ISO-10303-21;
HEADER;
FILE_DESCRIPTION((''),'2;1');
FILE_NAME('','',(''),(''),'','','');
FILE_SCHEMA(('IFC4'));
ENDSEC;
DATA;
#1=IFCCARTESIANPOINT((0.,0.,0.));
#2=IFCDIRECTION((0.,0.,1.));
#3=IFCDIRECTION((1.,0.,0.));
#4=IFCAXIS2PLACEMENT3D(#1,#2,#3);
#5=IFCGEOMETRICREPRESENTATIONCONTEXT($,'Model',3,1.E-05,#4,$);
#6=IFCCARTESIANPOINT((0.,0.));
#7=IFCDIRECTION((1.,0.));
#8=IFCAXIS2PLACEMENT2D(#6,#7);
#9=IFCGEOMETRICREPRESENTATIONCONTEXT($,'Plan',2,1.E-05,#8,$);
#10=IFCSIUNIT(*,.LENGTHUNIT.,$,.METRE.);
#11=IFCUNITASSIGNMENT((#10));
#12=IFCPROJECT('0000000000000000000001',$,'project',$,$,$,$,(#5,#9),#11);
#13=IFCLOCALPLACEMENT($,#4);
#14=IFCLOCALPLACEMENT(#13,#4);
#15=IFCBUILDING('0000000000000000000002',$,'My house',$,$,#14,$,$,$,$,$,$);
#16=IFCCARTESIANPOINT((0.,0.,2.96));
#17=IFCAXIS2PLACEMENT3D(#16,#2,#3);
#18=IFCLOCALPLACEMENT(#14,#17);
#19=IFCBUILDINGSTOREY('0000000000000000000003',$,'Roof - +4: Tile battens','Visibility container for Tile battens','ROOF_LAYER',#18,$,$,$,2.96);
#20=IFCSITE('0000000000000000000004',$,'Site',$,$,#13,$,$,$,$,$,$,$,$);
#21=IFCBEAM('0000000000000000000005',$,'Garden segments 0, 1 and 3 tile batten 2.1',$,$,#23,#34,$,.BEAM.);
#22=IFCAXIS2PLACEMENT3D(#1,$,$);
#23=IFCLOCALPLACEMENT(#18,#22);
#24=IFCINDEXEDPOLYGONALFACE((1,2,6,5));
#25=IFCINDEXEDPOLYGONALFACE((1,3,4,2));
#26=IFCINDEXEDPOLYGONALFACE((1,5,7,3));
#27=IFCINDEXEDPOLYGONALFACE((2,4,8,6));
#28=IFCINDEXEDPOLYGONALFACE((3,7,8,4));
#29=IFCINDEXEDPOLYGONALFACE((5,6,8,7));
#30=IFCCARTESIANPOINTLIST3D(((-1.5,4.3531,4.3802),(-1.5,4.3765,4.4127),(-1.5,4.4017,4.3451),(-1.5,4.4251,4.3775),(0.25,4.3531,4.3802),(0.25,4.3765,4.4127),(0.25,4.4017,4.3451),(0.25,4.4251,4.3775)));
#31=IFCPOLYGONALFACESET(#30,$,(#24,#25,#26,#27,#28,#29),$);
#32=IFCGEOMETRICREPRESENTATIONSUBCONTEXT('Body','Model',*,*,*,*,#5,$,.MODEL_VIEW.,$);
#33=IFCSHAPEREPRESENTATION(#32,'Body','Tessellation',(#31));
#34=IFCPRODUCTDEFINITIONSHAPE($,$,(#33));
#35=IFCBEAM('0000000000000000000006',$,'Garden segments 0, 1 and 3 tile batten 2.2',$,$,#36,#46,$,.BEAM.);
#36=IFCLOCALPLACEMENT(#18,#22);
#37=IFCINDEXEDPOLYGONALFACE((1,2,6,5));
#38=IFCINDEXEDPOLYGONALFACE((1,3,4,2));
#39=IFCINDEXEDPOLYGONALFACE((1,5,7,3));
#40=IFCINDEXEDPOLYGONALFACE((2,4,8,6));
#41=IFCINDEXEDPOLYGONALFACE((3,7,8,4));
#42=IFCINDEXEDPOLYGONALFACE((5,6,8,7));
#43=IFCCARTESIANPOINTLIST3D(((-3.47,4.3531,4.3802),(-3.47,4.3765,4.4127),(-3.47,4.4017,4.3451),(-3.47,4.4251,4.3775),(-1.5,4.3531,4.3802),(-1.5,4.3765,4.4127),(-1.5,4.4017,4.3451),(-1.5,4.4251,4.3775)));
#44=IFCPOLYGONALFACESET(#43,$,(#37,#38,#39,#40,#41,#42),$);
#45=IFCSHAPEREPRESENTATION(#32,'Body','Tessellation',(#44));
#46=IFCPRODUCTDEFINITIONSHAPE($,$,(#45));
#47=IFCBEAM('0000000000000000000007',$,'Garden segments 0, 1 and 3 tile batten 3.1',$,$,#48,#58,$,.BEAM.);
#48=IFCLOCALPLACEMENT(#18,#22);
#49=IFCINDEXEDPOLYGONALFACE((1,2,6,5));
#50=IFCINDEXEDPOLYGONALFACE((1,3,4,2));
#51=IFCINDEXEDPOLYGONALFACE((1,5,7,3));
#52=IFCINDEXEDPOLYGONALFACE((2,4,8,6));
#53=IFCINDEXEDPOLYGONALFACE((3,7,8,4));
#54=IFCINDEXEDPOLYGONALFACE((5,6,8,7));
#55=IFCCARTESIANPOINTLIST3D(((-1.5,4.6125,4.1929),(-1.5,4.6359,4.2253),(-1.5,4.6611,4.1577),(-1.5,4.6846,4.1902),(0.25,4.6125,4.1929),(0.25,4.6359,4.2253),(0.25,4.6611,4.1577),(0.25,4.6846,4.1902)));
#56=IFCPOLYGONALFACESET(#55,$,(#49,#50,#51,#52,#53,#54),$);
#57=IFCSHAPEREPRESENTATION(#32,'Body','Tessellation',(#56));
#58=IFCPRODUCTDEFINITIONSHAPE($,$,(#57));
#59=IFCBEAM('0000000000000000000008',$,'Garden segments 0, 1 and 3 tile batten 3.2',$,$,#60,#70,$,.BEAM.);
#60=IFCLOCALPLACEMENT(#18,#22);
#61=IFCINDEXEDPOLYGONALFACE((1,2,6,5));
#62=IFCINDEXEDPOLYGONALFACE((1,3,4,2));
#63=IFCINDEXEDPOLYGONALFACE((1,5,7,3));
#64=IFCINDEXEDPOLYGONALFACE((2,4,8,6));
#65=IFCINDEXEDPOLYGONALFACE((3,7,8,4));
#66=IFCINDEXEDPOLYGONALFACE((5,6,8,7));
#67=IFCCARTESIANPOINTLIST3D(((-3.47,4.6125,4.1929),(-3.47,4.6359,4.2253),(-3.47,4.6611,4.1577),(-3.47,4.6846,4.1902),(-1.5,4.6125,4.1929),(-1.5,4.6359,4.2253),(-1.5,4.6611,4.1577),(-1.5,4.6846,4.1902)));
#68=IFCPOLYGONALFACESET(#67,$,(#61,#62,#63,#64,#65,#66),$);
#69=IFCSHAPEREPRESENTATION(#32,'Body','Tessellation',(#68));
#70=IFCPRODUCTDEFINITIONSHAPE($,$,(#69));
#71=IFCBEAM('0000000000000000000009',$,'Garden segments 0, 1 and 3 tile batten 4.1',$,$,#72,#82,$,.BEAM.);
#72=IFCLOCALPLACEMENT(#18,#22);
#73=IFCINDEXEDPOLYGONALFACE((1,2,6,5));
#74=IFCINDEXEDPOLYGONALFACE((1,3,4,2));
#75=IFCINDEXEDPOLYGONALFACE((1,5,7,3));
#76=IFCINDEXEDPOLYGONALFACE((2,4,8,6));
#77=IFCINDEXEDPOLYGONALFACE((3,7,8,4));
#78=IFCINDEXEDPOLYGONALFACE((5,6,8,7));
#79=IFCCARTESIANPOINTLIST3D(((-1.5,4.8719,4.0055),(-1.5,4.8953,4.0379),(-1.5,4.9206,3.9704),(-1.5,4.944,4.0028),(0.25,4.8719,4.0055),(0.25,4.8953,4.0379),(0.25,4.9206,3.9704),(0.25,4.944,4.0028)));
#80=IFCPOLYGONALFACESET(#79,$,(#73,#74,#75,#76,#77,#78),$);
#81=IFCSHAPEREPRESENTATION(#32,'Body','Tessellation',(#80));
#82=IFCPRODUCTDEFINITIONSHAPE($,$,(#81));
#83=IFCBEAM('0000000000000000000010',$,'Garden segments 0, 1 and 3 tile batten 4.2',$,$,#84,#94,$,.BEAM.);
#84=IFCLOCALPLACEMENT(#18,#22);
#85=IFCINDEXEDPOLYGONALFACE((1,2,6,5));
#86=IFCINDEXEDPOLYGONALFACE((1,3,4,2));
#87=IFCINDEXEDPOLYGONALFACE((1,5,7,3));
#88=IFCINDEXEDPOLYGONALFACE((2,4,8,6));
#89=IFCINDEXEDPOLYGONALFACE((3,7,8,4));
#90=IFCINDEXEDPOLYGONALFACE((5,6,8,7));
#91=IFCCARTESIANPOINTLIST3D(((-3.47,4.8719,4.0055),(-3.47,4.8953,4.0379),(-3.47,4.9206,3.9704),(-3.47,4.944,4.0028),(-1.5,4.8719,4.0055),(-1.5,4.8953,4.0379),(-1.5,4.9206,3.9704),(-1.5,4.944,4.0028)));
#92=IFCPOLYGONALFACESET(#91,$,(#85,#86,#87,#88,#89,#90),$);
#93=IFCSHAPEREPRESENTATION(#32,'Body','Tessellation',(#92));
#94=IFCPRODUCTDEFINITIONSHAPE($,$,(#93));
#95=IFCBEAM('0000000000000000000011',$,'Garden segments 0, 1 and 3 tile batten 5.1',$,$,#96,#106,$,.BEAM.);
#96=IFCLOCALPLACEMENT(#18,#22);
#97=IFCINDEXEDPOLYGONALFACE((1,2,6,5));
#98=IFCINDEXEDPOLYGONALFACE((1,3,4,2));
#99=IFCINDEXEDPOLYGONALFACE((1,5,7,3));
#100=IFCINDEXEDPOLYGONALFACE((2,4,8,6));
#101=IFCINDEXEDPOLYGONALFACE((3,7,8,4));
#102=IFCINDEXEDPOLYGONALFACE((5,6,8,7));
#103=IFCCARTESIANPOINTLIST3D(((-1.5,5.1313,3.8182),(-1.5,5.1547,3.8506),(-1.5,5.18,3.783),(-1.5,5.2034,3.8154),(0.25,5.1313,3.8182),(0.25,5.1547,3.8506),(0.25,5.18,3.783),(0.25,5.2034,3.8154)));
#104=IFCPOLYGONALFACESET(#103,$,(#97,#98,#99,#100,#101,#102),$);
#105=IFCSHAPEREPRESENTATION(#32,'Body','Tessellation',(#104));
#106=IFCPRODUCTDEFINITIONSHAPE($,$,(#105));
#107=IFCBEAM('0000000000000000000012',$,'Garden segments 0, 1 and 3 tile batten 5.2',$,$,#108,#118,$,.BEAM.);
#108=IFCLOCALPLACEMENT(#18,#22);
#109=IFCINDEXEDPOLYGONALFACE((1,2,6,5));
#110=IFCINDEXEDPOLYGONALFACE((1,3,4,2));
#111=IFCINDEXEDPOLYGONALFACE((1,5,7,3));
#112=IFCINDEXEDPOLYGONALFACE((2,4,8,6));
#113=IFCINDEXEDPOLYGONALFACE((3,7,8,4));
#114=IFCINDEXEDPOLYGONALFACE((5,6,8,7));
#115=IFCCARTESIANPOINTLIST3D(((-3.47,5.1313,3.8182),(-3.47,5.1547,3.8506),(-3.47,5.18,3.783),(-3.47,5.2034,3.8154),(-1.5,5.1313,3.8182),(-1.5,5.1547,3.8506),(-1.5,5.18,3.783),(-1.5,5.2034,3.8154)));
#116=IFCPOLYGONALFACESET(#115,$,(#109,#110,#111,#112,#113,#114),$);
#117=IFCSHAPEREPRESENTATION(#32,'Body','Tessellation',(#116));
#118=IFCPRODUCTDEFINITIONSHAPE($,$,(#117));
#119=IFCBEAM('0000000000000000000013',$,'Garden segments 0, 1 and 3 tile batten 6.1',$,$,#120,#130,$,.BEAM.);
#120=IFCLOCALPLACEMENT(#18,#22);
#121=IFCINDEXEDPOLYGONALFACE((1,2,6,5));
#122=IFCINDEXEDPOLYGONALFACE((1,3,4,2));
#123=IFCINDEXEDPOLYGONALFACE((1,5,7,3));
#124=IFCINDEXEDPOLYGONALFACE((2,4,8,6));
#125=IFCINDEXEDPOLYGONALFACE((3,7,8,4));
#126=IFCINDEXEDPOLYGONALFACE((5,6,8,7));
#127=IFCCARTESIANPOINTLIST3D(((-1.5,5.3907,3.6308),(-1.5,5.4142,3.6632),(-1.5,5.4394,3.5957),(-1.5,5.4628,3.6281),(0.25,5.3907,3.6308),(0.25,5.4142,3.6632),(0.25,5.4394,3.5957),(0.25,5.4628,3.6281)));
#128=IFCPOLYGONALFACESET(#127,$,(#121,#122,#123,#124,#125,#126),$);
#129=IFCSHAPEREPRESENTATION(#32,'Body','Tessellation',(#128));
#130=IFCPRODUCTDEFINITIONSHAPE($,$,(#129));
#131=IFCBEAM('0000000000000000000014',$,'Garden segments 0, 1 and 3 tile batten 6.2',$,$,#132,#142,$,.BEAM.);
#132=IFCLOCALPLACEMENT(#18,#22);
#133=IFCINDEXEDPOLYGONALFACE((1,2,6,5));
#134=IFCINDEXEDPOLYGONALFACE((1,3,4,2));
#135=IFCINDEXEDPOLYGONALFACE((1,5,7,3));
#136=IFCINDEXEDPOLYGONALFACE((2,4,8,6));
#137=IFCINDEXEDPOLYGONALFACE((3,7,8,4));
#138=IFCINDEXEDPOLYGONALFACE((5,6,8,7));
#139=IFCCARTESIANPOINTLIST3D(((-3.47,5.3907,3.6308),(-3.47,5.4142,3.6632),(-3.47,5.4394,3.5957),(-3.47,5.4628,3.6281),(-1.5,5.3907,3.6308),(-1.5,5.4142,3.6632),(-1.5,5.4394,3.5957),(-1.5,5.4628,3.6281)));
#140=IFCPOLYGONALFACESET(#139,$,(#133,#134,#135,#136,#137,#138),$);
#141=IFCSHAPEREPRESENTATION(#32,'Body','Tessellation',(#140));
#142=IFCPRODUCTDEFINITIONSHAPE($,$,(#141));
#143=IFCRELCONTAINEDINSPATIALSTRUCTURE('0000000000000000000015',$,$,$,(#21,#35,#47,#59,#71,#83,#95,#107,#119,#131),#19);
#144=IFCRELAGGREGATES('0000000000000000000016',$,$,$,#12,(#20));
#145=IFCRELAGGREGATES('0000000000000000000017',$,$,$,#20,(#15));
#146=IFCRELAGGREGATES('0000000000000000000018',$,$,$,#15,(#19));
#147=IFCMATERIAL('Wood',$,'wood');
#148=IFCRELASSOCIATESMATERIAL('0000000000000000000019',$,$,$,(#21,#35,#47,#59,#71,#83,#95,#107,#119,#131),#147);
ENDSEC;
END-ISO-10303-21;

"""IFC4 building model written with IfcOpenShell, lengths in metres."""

from ifc_helpers import new_model, si_unit, frame, origin_with_axes, origin_2d_with_axis, place, context, subcontext, project, spatial, rectangle, extrude, clip, halfspace, source, transform, mapped, material, element, save


model = new_model("IFC4")

# Units and contexts
model_context = context("Model", 3, precision=1e-05, world=origin_with_axes())
plan_context = context("Plan", 2, precision=1e-05, world=origin_2d_with_axis())
body_context = subcontext(model_context, "Body", "Model", "MODEL_VIEW")
ifc_project = project(units=[si_unit("LENGTHUNIT", "METRE")], contexts=[model_context, plan_context])

# Site, building, storey
site_placement = place(None, origin_with_axes())
site = spatial("IfcSite", under=ifc_project, at=site_placement, Name="Site")
building_placement = place(site_placement, origin_with_axes())
building = spatial("IfcBuilding", under=site, at=building_placement, Name="My house")
storey_placement = place(building_placement, frame((0.0, 0.0, 2.96), z_axis=(0.0, 0.0, 1.0), x_axis=(1.0, 0.0, 0.0)))
storey = spatial("IfcBuildingStorey", under=building, at=storey_placement, Name="Roof - +4: Tile battens", Description="Visibility container for Tile battens", ObjectType="ROOF_LAYER", Elevation=2.96)

# Beams
ifc_material = material(Name="Wood", Category="wood")
shared_shape_1 = source(origin_with_axes(), body_context, "Body", "Clipping", [
    clip(clip(extrude(rectangle(XDim=0.06, YDim=0.04), frame((0.0, 0.0, 0.0), z_axis=(1.0, 0.0, 0.0), x_axis=(0.0, 1.0, 0.0)), (0.0, 0.0, 1.0), 1.75), halfspace(frame((0.25, 3.9816, -6.1772), z_axis=(0.0, -0.810664, -0.585512), x_axis=(-1.0, 0.0, 0.0)), False)), halfspace(frame((0.25, 7.8322, -3.396), z_axis=(0.0, 0.810664, 0.585512), x_axis=(1.0, 0.0, 0.0)), False)),
])
beam_1_placement = place(storey_placement, frame((0.25, 4.3891, 4.3789), z_axis=(0.0, 0.585512, 0.810664), x_axis=(1.0, 0.0, 0.0)))
element("IfcBeam", 1, at=beam_1_placement, inside=storey, material=ifc_material, Name="Garden segments 0, 1 and 3 tile batten 2.1", PredefinedType="BEAM", context=body_context, shape_type="MappedRepresentation", body=[
    mapped(shared_shape_1, transform((0.0, 0.0, 0.0), x_axis=(-1.0, 0.0, 0.0), y_axis=(0.0, 1.0, 0.0), z_axis=(0.0, 0.0, 1.0), scale=1.0)),
])
shared_shape_2 = source(origin_with_axes(), body_context, "Body", "Clipping", [
    clip(clip(extrude(rectangle(XDim=0.06, YDim=0.04), frame((0.0, 0.0, 0.0), z_axis=(1.0, 0.0, 0.0), x_axis=(0.0, 1.0, 0.0)), (0.0, 0.0, 1.0), 1.97), halfspace(frame((-1.5, 3.9816, -6.1772), z_axis=(0.0, -0.810664, -0.585512), x_axis=(-1.0, 0.0, 0.0)), False)), halfspace(frame((-1.5, 7.8322, -3.396), z_axis=(0.0, 0.810664, 0.585512), x_axis=(1.0, 0.0, 0.0)), False)),
])
beam_2_placement = place(storey_placement, frame((-1.5, 4.3891, 4.3789), z_axis=(0.0, 0.585512, 0.810664), x_axis=(1.0, 0.0, 0.0)))
element("IfcBeam", 2, at=beam_2_placement, inside=storey, material=ifc_material, Name="Garden segments 0, 1 and 3 tile batten 2.2", PredefinedType="BEAM", context=body_context, shape_type="MappedRepresentation", body=[
    mapped(shared_shape_2, transform((0.0, 0.0, 0.0), x_axis=(-1.0, 0.0, 0.0), y_axis=(0.0, 1.0, 0.0), z_axis=(0.0, 0.0, 1.0), scale=1.0)),
])
shared_shape_3 = source(origin_with_axes(), body_context, "Body", "Clipping", [
    clip(clip(extrude(rectangle(XDim=0.06, YDim=0.04), frame((0.0, 0.0, 0.0), z_axis=(1.0, 0.0, 0.0), x_axis=(0.0, 1.0, 0.0)), (0.0, 0.0, 1.0), 1.75), halfspace(frame((0.25, 3.6616, -6.1772), z_axis=(0.0, -0.810664, -0.585512), x_axis=(-1.0, 0.0, 0.0)), False)), halfspace(frame((0.25, 7.5122, -3.396), z_axis=(0.0, 0.810664, 0.585512), x_axis=(1.0, 0.0, 0.0)), False)),
])
beam_3_placement = place(storey_placement, frame((0.25, 4.6485, 4.1915), z_axis=(0.0, 0.585512, 0.810664), x_axis=(1.0, 0.0, 0.0)))
element("IfcBeam", 3, at=beam_3_placement, inside=storey, material=ifc_material, Name="Garden segments 0, 1 and 3 tile batten 3.1", PredefinedType="BEAM", context=body_context, shape_type="MappedRepresentation", body=[
    mapped(shared_shape_3, transform((0.0, 0.0, 0.0), x_axis=(-1.0, 0.0, 0.0), y_axis=(0.0, 1.0, 0.0), z_axis=(0.0, 0.0, 1.0), scale=1.0)),
])
shared_shape_4 = source(origin_with_axes(), body_context, "Body", "Clipping", [
    clip(clip(extrude(rectangle(XDim=0.06, YDim=0.04), frame((0.0, 0.0, 0.0), z_axis=(1.0, 0.0, 0.0), x_axis=(0.0, 1.0, 0.0)), (0.0, 0.0, 1.0), 1.97), halfspace(frame((-1.5, 3.6616, -6.1772), z_axis=(0.0, -0.810664, -0.585512), x_axis=(-1.0, 0.0, 0.0)), False)), halfspace(frame((-1.5, 7.5122, -3.396), z_axis=(0.0, 0.810664, 0.585512), x_axis=(1.0, 0.0, 0.0)), False)),
])
beam_4_placement = place(storey_placement, frame((-1.5, 4.6485, 4.1915), z_axis=(0.0, 0.585512, 0.810664), x_axis=(1.0, 0.0, 0.0)))
element("IfcBeam", 4, at=beam_4_placement, inside=storey, material=ifc_material, Name="Garden segments 0, 1 and 3 tile batten 3.2", PredefinedType="BEAM", context=body_context, shape_type="MappedRepresentation", body=[
    mapped(shared_shape_4, transform((0.0, 0.0, 0.0), x_axis=(-1.0, 0.0, 0.0), y_axis=(0.0, 1.0, 0.0), z_axis=(0.0, 0.0, 1.0), scale=1.0)),
])
shared_shape_5 = source(origin_with_axes(), body_context, "Body", "Clipping", [
    clip(clip(extrude(rectangle(XDim=0.06, YDim=0.04), frame((0.0, 0.0, 0.0), z_axis=(1.0, 0.0, 0.0), x_axis=(0.0, 1.0, 0.0)), (0.0, 0.0, 1.0), 1.75), halfspace(frame((0.25, 3.3416, -6.1772), z_axis=(0.0, -0.810664, -0.585512), x_axis=(-1.0, 0.0, 0.0)), False)), halfspace(frame((0.25, 7.1922, -3.396), z_axis=(0.0, 0.810664, 0.585512), x_axis=(1.0, 0.0, 0.0)), False)),
])
beam_5_placement = place(storey_placement, frame((0.25, 4.9079, 4.0042), z_axis=(0.0, 0.585512, 0.810664), x_axis=(1.0, 0.0, 0.0)))
element("IfcBeam", 5, at=beam_5_placement, inside=storey, material=ifc_material, Name="Garden segments 0, 1 and 3 tile batten 4.1", PredefinedType="BEAM", context=body_context, shape_type="MappedRepresentation", body=[
    mapped(shared_shape_5, transform((0.0, 0.0, 0.0), x_axis=(-1.0, 0.0, 0.0), y_axis=(0.0, 1.0, 0.0), z_axis=(0.0, 0.0, 1.0), scale=1.0)),
])
shared_shape_6 = source(origin_with_axes(), body_context, "Body", "Clipping", [
    clip(clip(extrude(rectangle(XDim=0.06, YDim=0.04), frame((0.0, 0.0, 0.0), z_axis=(1.0, 0.0, 0.0), x_axis=(0.0, 1.0, 0.0)), (0.0, 0.0, 1.0), 1.97), halfspace(frame((-1.5, 3.3416, -6.1772), z_axis=(0.0, -0.810664, -0.585512), x_axis=(-1.0, 0.0, 0.0)), False)), halfspace(frame((-1.5, 7.1922, -3.396), z_axis=(0.0, 0.810664, 0.585512), x_axis=(1.0, 0.0, 0.0)), False)),
])
beam_6_placement = place(storey_placement, frame((-1.5, 4.9079, 4.0042), z_axis=(0.0, 0.585512, 0.810664), x_axis=(1.0, 0.0, 0.0)))
element("IfcBeam", 6, at=beam_6_placement, inside=storey, material=ifc_material, Name="Garden segments 0, 1 and 3 tile batten 4.2", PredefinedType="BEAM", context=body_context, shape_type="MappedRepresentation", body=[
    mapped(shared_shape_6, transform((0.0, 0.0, 0.0), x_axis=(-1.0, 0.0, 0.0), y_axis=(0.0, 1.0, 0.0), z_axis=(0.0, 0.0, 1.0), scale=1.0)),
])
shared_shape_7 = source(origin_with_axes(), body_context, "Body", "Clipping", [
    clip(clip(extrude(rectangle(XDim=0.06, YDim=0.04), frame((0.0, 0.0, 0.0), z_axis=(1.0, 0.0, 0.0), x_axis=(0.0, 1.0, 0.0)), (0.0, 0.0, 1.0), 1.75), halfspace(frame((0.25, 3.0216, -6.1772), z_axis=(0.0, -0.810664, -0.585512), x_axis=(-1.0, 0.0, 0.0)), False)), halfspace(frame((0.25, 6.8722, -3.396), z_axis=(0.0, 0.810664, 0.585512), x_axis=(1.0, 0.0, 0.0)), False)),
])
beam_7_placement = place(storey_placement, frame((0.25, 5.1674, 3.8168), z_axis=(0.0, 0.585512, 0.810664), x_axis=(1.0, 0.0, 0.0)))
element("IfcBeam", 7, at=beam_7_placement, inside=storey, material=ifc_material, Name="Garden segments 0, 1 and 3 tile batten 5.1", PredefinedType="BEAM", context=body_context, shape_type="MappedRepresentation", body=[
    mapped(shared_shape_7, transform((0.0, 0.0, 0.0), x_axis=(-1.0, 0.0, 0.0), y_axis=(0.0, 1.0, 0.0), z_axis=(0.0, 0.0, 1.0), scale=1.0)),
])
shared_shape_8 = source(origin_with_axes(), body_context, "Body", "Clipping", [
    clip(clip(extrude(rectangle(XDim=0.06, YDim=0.04), frame((0.0, 0.0, 0.0), z_axis=(1.0, 0.0, 0.0), x_axis=(0.0, 1.0, 0.0)), (0.0, 0.0, 1.0), 1.97), halfspace(frame((-1.5, 3.0216, -6.1772), z_axis=(0.0, -0.810664, -0.585512), x_axis=(-1.0, 0.0, 0.0)), False)), halfspace(frame((-1.5, 6.8722, -3.396), z_axis=(0.0, 0.810664, 0.585512), x_axis=(1.0, 0.0, 0.0)), False)),
])
beam_8_placement = place(storey_placement, frame((-1.5, 5.1674, 3.8168), z_axis=(0.0, 0.585512, 0.810664), x_axis=(1.0, 0.0, 0.0)))
element("IfcBeam", 8, at=beam_8_placement, inside=storey, material=ifc_material, Name="Garden segments 0, 1 and 3 tile batten 5.2", PredefinedType="BEAM", context=body_context, shape_type="MappedRepresentation", body=[
    mapped(shared_shape_8, transform((0.0, 0.0, 0.0), x_axis=(-1.0, 0.0, 0.0), y_axis=(0.0, 1.0, 0.0), z_axis=(0.0, 0.0, 1.0), scale=1.0)),
])
shared_shape_9 = source(origin_with_axes(), body_context, "Body", "Clipping", [
    clip(clip(extrude(rectangle(XDim=0.06, YDim=0.04), frame((0.0, 0.0, 0.0), z_axis=(1.0, 0.0, 0.0), x_axis=(0.0, 1.0, 0.0)), (0.0, 0.0, 1.0), 1.75), halfspace(frame((0.25, 2.7016, -6.1772), z_axis=(0.0, -0.810664, -0.585512), x_axis=(-1.0, 0.0, 0.0)), False)), halfspace(frame((0.25, 6.5522, -3.396), z_axis=(0.0, 0.810664, 0.585512), x_axis=(1.0, 0.0, 0.0)), False)),
])
beam_9_placement = place(storey_placement, frame((0.25, 5.4268, 3.6294), z_axis=(0.0, 0.585512, 0.810664), x_axis=(1.0, 0.0, 0.0)))
element("IfcBeam", 9, at=beam_9_placement, inside=storey, material=ifc_material, Name="Garden segments 0, 1 and 3 tile batten 6.1", PredefinedType="BEAM", context=body_context, shape_type="MappedRepresentation", body=[
    mapped(shared_shape_9, transform((0.0, 0.0, 0.0), x_axis=(-1.0, 0.0, 0.0), y_axis=(0.0, 1.0, 0.0), z_axis=(0.0, 0.0, 1.0), scale=1.0)),
])
shared_shape_10 = source(origin_with_axes(), body_context, "Body", "Clipping", [
    clip(clip(extrude(rectangle(XDim=0.06, YDim=0.04), frame((0.0, 0.0, 0.0), z_axis=(1.0, 0.0, 0.0), x_axis=(0.0, 1.0, 0.0)), (0.0, 0.0, 1.0), 1.97), halfspace(frame((-1.5, 2.7016, -6.1772), z_axis=(0.0, -0.810664, -0.585512), x_axis=(-1.0, 0.0, 0.0)), False)), halfspace(frame((-1.5, 6.5522, -3.396), z_axis=(0.0, 0.810664, 0.585512), x_axis=(1.0, 0.0, 0.0)), False)),
])
beam_10_placement = place(storey_placement, frame((-1.5, 5.4268, 3.6294), z_axis=(0.0, 0.585512, 0.810664), x_axis=(1.0, 0.0, 0.0)))
element("IfcBeam", 10, at=beam_10_placement, inside=storey, material=ifc_material, Name="Garden segments 0, 1 and 3 tile batten 6.2", PredefinedType="BEAM", context=body_context, shape_type="MappedRepresentation", body=[
    mapped(shared_shape_10, transform((0.0, 0.0, 0.0), x_axis=(-1.0, 0.0, 0.0), y_axis=(0.0, 1.0, 0.0), z_axis=(0.0, 0.0, 1.0), scale=1.0)),
])

save(model, "model.ifc")
